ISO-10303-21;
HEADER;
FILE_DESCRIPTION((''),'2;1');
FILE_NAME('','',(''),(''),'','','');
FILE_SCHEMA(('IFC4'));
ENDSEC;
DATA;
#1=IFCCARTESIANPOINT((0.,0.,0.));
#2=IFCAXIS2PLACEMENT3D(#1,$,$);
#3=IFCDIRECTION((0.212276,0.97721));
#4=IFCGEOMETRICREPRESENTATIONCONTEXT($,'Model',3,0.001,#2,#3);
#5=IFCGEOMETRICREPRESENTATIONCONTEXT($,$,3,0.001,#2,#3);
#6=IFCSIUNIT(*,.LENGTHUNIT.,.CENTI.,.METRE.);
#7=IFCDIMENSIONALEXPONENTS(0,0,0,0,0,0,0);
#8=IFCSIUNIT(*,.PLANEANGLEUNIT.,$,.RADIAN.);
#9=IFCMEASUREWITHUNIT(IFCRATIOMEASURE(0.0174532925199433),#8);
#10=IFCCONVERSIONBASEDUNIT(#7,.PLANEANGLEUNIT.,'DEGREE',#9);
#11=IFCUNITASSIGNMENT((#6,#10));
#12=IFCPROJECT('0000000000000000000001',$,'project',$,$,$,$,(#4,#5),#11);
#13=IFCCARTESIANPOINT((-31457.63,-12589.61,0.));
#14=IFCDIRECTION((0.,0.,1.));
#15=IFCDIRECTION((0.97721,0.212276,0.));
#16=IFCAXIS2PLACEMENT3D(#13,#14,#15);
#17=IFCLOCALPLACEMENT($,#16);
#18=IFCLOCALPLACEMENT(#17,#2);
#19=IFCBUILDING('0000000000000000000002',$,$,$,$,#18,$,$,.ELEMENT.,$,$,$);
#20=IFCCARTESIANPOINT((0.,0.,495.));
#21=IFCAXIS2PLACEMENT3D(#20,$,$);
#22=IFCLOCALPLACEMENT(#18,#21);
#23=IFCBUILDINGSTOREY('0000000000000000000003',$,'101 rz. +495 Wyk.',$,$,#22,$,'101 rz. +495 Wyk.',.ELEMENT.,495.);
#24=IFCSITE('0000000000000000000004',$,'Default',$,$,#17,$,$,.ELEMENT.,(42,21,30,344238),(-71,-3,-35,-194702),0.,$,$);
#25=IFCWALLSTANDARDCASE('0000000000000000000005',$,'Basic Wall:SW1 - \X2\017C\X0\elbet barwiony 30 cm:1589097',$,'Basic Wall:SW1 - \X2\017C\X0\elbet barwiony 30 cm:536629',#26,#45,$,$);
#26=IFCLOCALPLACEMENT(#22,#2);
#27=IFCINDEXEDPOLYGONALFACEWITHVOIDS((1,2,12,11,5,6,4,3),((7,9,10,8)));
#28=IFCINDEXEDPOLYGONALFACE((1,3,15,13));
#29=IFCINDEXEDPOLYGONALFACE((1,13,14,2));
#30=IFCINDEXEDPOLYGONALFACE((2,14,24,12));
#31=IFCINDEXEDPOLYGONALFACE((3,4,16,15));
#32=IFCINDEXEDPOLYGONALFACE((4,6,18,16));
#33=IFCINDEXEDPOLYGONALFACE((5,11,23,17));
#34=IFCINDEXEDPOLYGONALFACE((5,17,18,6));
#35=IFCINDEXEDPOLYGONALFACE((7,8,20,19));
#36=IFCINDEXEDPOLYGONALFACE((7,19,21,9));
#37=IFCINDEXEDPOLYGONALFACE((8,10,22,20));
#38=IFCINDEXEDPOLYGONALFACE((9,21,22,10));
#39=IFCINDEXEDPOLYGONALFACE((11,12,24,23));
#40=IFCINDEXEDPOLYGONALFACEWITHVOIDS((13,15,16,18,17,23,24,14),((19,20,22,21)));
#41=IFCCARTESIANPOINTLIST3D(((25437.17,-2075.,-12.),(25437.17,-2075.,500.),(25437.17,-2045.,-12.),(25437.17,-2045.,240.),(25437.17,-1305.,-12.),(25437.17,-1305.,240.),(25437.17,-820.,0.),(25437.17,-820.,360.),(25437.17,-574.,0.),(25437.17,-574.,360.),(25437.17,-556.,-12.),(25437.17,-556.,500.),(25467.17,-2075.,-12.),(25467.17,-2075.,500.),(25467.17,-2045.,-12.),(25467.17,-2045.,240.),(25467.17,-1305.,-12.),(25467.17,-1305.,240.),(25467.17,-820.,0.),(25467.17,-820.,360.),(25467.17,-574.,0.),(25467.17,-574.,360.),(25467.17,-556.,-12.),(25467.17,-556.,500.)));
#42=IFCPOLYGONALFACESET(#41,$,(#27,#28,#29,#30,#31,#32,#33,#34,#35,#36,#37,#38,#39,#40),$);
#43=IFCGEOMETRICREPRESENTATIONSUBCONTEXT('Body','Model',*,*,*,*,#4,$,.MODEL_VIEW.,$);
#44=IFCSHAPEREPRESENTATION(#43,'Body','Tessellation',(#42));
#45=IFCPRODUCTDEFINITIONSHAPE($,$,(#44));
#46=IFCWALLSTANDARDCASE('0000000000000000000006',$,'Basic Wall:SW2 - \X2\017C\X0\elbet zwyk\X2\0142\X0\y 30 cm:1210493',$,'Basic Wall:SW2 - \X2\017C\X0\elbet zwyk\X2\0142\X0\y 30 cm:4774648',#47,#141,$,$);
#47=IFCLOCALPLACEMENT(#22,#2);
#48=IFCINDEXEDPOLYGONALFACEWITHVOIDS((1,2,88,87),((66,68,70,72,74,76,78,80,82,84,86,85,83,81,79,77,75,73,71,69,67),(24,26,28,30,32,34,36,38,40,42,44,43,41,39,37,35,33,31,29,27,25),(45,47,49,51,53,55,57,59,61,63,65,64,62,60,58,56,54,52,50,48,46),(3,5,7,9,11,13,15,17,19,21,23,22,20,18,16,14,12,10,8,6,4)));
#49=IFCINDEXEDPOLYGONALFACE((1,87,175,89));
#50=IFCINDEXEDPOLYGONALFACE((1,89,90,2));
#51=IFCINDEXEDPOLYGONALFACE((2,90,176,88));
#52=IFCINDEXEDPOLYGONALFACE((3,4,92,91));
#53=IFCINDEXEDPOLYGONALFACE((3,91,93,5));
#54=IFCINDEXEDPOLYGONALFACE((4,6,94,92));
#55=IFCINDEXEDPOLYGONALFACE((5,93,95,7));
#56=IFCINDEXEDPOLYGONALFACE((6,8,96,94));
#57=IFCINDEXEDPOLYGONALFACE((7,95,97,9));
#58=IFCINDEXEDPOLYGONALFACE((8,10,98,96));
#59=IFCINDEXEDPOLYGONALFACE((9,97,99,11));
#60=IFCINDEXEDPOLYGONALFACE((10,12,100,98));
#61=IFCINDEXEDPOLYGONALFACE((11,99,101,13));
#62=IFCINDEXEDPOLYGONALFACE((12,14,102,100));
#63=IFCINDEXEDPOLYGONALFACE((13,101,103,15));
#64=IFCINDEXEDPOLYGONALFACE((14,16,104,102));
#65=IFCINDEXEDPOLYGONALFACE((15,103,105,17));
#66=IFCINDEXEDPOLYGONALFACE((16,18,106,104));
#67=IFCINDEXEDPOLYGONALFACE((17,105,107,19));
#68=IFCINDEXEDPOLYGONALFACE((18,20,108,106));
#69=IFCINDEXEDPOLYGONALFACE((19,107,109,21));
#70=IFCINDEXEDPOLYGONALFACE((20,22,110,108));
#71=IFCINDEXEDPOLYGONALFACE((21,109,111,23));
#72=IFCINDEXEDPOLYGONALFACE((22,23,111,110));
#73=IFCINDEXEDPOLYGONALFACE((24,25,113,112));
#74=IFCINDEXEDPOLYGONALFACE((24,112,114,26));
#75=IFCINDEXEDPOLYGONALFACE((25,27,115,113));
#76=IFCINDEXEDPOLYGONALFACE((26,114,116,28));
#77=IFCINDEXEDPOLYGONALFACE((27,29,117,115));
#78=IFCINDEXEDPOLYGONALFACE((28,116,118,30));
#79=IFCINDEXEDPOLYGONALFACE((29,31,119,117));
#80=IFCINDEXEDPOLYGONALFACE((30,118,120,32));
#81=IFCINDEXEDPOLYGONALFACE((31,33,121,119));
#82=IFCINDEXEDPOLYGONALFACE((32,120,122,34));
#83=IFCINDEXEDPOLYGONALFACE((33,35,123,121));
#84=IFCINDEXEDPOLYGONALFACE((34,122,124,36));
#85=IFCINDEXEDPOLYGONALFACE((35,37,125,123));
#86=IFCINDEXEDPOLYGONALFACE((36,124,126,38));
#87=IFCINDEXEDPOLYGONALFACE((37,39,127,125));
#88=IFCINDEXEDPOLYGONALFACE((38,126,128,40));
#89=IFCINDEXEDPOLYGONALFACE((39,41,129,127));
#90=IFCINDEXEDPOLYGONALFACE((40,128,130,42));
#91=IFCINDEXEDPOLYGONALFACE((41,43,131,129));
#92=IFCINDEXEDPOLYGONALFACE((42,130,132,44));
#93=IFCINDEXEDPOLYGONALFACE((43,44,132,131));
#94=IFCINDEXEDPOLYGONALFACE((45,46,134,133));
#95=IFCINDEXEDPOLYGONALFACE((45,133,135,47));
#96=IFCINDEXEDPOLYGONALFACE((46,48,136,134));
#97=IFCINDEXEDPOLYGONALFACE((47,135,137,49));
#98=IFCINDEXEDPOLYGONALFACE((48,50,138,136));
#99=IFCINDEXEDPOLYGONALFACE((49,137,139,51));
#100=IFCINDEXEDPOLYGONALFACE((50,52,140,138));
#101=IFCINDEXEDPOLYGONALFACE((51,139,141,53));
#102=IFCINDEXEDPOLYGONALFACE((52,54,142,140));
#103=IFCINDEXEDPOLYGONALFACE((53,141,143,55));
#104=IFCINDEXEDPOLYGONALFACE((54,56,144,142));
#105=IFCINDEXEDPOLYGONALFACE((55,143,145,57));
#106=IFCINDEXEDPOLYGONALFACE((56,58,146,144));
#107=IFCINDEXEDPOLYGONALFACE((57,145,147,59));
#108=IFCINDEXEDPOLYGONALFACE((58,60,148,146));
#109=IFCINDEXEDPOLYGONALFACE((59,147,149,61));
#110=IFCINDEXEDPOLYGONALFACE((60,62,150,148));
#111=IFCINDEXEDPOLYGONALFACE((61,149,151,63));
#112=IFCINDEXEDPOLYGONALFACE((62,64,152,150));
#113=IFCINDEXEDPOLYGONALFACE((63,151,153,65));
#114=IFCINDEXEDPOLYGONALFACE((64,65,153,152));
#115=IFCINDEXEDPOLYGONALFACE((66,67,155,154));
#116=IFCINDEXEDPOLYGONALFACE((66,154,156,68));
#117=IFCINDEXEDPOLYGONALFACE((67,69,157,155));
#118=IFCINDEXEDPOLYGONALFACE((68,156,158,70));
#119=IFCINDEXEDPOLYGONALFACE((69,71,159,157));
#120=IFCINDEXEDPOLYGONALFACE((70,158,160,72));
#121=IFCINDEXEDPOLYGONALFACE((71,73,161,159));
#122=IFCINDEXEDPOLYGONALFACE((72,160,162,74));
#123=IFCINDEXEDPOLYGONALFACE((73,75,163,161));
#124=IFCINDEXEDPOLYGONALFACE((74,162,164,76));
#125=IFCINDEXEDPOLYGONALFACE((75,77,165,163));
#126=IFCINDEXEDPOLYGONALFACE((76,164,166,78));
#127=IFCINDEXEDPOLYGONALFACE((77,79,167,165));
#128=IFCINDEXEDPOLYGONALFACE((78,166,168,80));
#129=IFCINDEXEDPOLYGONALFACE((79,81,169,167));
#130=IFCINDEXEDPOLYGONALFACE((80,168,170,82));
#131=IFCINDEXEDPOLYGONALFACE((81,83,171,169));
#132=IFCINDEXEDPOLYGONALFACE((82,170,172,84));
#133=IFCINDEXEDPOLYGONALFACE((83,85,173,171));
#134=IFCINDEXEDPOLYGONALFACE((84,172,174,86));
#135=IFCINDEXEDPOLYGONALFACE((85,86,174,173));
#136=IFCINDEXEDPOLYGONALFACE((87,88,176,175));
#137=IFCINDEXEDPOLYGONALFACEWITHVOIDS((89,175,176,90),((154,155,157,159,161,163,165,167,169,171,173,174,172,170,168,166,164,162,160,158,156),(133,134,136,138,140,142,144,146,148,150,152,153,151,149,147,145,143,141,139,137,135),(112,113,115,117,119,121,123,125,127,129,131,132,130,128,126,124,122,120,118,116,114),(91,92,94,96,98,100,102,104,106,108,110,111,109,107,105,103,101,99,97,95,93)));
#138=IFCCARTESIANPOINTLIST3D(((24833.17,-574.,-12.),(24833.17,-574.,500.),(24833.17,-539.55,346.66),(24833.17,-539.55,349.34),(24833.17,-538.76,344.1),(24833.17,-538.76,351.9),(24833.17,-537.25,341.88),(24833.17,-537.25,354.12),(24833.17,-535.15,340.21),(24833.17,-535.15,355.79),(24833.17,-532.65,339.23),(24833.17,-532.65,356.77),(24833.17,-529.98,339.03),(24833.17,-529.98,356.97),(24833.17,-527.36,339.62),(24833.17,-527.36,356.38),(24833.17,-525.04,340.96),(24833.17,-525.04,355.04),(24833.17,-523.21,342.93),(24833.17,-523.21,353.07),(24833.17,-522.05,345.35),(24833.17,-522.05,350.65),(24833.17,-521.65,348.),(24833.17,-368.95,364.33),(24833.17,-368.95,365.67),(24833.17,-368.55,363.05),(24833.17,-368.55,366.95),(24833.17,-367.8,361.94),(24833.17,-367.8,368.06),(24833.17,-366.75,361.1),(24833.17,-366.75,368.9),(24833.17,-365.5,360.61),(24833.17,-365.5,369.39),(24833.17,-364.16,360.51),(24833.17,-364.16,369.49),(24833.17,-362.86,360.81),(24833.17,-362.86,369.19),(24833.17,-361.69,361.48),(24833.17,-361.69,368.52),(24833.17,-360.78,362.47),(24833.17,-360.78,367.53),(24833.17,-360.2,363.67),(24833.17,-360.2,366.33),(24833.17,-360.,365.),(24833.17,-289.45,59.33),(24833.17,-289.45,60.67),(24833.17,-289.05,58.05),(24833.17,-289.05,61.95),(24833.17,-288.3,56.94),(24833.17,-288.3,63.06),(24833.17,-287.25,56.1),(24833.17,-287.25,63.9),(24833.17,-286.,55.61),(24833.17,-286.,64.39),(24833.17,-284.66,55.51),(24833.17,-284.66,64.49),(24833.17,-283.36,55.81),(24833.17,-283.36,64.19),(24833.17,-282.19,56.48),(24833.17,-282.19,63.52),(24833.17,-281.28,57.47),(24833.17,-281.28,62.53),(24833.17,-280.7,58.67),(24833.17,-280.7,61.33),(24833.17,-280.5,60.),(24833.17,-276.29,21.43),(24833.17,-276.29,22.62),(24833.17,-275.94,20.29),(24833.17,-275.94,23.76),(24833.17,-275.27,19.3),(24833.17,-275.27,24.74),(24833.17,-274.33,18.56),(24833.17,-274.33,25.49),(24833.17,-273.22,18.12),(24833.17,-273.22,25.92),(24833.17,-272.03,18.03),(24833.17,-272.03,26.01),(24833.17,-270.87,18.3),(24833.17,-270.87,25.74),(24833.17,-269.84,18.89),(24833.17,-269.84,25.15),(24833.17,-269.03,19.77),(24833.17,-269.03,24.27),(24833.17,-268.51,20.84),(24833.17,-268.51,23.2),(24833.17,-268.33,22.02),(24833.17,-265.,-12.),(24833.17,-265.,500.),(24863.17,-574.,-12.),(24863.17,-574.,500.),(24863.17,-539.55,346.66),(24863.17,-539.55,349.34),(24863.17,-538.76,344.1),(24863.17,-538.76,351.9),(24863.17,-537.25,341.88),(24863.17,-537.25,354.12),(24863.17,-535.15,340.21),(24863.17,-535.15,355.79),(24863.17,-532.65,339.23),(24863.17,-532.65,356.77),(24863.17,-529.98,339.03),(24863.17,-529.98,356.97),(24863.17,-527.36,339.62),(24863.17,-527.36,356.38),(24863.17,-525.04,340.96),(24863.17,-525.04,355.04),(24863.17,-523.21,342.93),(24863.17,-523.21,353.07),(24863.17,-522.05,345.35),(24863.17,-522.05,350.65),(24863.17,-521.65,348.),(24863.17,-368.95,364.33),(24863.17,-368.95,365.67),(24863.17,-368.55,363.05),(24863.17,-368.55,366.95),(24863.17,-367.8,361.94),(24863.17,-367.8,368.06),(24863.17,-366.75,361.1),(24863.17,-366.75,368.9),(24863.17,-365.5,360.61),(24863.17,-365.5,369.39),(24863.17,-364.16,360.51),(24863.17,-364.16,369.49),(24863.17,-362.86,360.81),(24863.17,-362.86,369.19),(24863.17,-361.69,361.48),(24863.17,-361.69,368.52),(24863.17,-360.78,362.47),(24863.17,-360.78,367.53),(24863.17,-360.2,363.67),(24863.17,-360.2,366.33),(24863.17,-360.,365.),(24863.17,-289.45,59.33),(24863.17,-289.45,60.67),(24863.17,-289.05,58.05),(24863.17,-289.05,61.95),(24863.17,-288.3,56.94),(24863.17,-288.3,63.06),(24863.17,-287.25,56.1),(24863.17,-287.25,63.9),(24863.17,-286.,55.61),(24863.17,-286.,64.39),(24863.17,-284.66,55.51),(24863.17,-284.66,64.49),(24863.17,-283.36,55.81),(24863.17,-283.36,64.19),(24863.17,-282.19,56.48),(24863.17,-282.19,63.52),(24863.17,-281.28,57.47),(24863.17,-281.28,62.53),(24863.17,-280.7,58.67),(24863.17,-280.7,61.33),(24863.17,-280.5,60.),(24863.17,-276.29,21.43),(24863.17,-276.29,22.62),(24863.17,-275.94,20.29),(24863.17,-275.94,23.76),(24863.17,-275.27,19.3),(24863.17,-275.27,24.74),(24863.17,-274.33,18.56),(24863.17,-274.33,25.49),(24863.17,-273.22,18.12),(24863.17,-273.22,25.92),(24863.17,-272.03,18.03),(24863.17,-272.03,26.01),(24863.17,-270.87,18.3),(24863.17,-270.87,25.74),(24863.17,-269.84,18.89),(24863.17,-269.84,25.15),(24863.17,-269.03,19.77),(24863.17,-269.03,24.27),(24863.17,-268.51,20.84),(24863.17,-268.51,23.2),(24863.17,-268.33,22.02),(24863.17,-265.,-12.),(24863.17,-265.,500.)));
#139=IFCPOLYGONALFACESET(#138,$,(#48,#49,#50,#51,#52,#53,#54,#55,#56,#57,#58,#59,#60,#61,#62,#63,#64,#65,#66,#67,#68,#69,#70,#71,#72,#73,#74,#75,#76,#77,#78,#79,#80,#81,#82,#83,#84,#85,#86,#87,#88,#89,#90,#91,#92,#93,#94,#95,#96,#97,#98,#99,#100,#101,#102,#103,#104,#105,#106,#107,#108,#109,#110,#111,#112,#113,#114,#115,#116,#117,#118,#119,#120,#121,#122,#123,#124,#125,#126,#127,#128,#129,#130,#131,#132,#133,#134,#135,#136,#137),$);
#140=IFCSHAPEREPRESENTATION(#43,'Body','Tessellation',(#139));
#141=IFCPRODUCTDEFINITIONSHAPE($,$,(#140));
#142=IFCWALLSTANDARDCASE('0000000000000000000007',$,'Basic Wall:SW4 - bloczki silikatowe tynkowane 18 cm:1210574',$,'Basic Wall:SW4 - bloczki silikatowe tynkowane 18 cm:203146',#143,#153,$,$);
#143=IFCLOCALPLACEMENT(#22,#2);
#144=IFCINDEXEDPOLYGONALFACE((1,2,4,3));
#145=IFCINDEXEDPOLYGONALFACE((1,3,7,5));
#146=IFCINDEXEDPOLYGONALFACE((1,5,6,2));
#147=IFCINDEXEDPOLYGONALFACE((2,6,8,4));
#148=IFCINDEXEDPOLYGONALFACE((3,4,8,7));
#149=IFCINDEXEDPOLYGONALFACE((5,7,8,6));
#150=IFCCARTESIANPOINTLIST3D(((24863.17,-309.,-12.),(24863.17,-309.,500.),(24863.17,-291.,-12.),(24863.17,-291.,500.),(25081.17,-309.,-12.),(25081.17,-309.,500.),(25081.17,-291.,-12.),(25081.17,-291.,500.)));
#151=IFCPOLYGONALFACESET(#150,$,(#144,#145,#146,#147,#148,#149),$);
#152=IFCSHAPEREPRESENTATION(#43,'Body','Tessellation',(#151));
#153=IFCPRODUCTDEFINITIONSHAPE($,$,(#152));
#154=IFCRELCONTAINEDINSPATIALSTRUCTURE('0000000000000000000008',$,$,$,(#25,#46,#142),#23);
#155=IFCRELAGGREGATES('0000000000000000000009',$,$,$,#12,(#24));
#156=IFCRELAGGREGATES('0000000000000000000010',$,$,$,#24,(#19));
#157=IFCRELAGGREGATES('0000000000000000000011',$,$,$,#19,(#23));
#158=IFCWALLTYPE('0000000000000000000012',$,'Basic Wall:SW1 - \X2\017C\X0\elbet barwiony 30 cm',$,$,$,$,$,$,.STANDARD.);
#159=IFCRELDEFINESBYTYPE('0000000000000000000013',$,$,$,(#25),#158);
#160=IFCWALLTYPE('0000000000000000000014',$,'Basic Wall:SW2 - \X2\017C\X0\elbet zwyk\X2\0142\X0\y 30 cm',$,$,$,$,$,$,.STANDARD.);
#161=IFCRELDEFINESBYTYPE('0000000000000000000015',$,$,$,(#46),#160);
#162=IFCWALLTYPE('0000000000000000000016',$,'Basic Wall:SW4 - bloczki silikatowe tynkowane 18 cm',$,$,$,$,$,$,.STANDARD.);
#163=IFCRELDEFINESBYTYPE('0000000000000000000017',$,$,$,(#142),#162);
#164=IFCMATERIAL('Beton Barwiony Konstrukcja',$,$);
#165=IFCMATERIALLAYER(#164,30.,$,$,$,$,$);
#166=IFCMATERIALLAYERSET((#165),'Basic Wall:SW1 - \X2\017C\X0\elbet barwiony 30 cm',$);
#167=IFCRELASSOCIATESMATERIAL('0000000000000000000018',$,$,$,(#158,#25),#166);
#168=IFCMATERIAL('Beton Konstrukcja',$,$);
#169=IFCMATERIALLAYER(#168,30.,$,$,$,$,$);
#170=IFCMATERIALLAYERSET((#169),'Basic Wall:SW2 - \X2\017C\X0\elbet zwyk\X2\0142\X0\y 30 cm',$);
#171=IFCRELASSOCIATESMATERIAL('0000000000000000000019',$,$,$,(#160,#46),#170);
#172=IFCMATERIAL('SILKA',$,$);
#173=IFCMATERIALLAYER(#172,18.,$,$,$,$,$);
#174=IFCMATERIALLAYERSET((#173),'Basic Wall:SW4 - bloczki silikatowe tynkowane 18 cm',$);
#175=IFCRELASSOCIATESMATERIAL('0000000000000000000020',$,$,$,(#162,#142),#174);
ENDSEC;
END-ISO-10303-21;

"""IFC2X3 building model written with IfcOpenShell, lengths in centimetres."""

from ifc_helpers import new_model, entity, si_unit, converted_unit, direction, frame, frame_2d, origin, place, context, subcontext, project, spatial, polyline, rectangle, circle, extrude, clip, bounded_halfspace, material, layer, layer_set, layer_usage, type_object, element, save


model = new_model("IFC2X3")

# Units and contexts
model_context = context("Model", 3, precision=0.001, world=origin(), true_north=direction((0.212276, 0.97721)))
context_of_model = context(None, 3, precision=0.001, world=origin(), true_north=direction((0.212276, 0.97721)))
body_context = subcontext(model_context, "Body", "Model", "MODEL_VIEW")
ifc_project = project(units=[si_unit("LENGTHUNIT", "METRE", prefix="CENTI"), converted_unit("PLANEANGLEUNIT", "DEGREE", entity("IfcRatioMeasure", 0.0174532925199433), si_unit("PLANEANGLEUNIT", "RADIAN"), dimensions=[0, 0, 0, 0, 0, 0, 0])], contexts=[model_context, context_of_model])

# Site, building, storey
site_placement = place(None, frame((-31457.63, -12589.61, 0.0), z_axis=(0.0, 0.0, 1.0), x_axis=(0.97721, 0.212276, 0.0)))
site = spatial("IfcSite", under=ifc_project, at=site_placement, Name="Default", CompositionType="ELEMENT", RefLatitude=(42, 21, 30, 344238), RefLongitude=(-71, -3, -35, -194702), RefElevation=0.0)
building_placement = place(site_placement, origin())
building = spatial("IfcBuilding", under=site, at=building_placement, CompositionType="ELEMENT")
storey_placement = place(building_placement, frame((0.0, 0.0, 495.0)))
storey = spatial("IfcBuildingStorey", under=building, at=storey_placement, Name="101 rz. +495 Wyk.", LongName="101 rz. +495 Wyk.", CompositionType="ELEMENT", Elevation=495.0)

# Walls, openings
ifc_material_1 = material(Name="Beton Barwiony Konstrukcja")
ifc_layer_1 = layer(ifc_material_1, 30.0)
ifc_layer_set_1 = layer_set([ifc_layer_1], Name="Basic Wall:SW1 - żelbet barwiony 30 cm")
ifc_layer_usage_1 = layer_usage(ifc_layer_set_1, "AXIS2", "NEGATIVE", 15.0)
wall_type_1 = type_object("IfcWallType", Name="Basic Wall:SW1 - żelbet barwiony 30 cm", PredefinedType="STANDARD", material=ifc_layer_set_1)
wall_1_placement = place(storey_placement, frame((25452.17, -556.0, -12.0), z_axis=(0.0, 0.0, 1.0), x_axis=(0.0, -1.0, 0.0)))
wall_1 = element("IfcWallStandardCase", 1, at=wall_1_placement, inside=storey, type_object=wall_type_1, material=ifc_layer_usage_1, Name="Basic Wall:SW1 - żelbet barwiony 30 cm:1589097", ObjectType="Basic Wall:SW1 - żelbet barwiony 30 cm:536629", context=body_context, shape_type="Clipping", body=[
    clip(extrude(rectangle(XDim=1519.0, YDim=30.0, at=frame_2d((759.5, 0.0), x_axis=(-1.0, 0.0))), origin(), (0.0, 0.0, 1.0), 537.0), bounded_halfspace(frame((1519.0, 15.0, 512.0), z_axis=(0.0, 0.0, -1.0), x_axis=(0.0, 1.0, 0.0)), True, frame((1519.0, 15.0, 512.0)), polyline([(0.0, 0.0), (-1519.0, 0.0), (-1519.0, -30.0), (-820.0, -30.0), (-790.0, -30.0), (0.0, -30.0), (0.0, 0.0)]))),
])
opening_1_placement = place(wall_1_placement, frame((264.0, -30.24, 12.0)))
element("IfcOpeningElement", 2, at=opening_1_placement, cuts=wall_1, ObjectType="Opening", context=body_context, shape_type="SweptSolid", body=[
    extrude(rectangle(XDim=360.0, YDim=246.0, at=frame_2d((0.0, 0.0), x_axis=(0.0, 1.0))), frame((-123.0, 0.0, 180.0), z_axis=(0.0, 1.0, 0.0), x_axis=(-1.0, 0.0, 0.0)), (0.0, 0.0, 1.0), 60.48),
])
opening_2_placement = place(wall_1_placement, origin())
element("IfcOpeningElement", 3, at=opening_2_placement, cuts=wall_1, ObjectType="Opening", context=body_context, shape_type="SweptSolid", body=[
    extrude(rectangle(XDim=252.0, YDim=740.0, at=frame_2d((0.0, 0.0), x_axis=(0.0, 1.0))), frame((1119.0, 15.0, 126.0), z_axis=(0.0, -1.0, 0.0), x_axis=(1.0, 0.0, 0.0)), (0.0, 0.0, 1.0), 30.0),
])
ifc_material_2 = material(Name="Beton Konstrukcja")
ifc_layer_2 = layer(ifc_material_2, 30.0)
ifc_layer_set_2 = layer_set([ifc_layer_2], Name="Basic Wall:SW2 - żelbet zwykły 30 cm")
ifc_layer_usage_2 = layer_usage(ifc_layer_set_2, "AXIS2", "NEGATIVE", 15.0)
wall_type_2 = type_object("IfcWallType", Name="Basic Wall:SW2 - żelbet zwykły 30 cm", PredefinedType="STANDARD", material=ifc_layer_set_2)
wall_2_placement = place(storey_placement, frame((24848.17, -265.0, -12.0), z_axis=(0.0, 0.0, 1.0), x_axis=(0.0, -1.0, 0.0)))
wall_2 = element("IfcWallStandardCase", 4, at=wall_2_placement, inside=storey, type_object=wall_type_2, material=ifc_layer_usage_2, Name="Basic Wall:SW2 - żelbet zwykły 30 cm:1210493", ObjectType="Basic Wall:SW2 - żelbet zwykły 30 cm:4774648", context=body_context, shape_type="Clipping", body=[
    clip(extrude(rectangle(XDim=309.0, YDim=30.0, at=frame_2d((154.5, 0.0), x_axis=(-1.0, 0.0))), origin(), (0.0, 0.0, 1.0), 537.0), bounded_halfspace(frame((0.0, -15.0, 512.0), z_axis=(0.0, 0.0, -1.0), x_axis=(0.0, 1.0, 0.0)), True, frame((0.0, -15.0, 512.0)), polyline([(0.0, 0.0), (309.0, 0.0), (309.0, 30.0), (0.0, 30.0), (0.0, 0.0)]))),
])
opening_3_placement = place(wall_2_placement, origin())
element("IfcOpeningElement", 5, at=opening_3_placement, cuts=wall_2, ObjectType="Opening", context=body_context, shape_type="SweptSolid", body=[
    extrude(circle(Radius=9.0, at=frame_2d((0.0, 0.0), x_axis=(1.0, 0.0))), frame((265.65, 15.0, 360.0), z_axis=(0.0, -1.0, 0.0), x_axis=(-1.0, 0.0, 0.0)), (0.0, 0.0, 1.0), 30.0),
])
opening_4_placement = place(wall_2_placement, origin())
element("IfcOpeningElement", 6, at=opening_4_placement, cuts=wall_2, ObjectType="Opening", context=body_context, shape_type="SweptSolid", body=[
    extrude(circle(Radius=4.5, at=frame_2d((0.0, 0.0), x_axis=(1.0, 0.0))), frame((99.5, 15.0, 377.0), z_axis=(0.0, -1.0, 0.0), x_axis=(-1.0, 0.0, 0.0)), (0.0, 0.0, 1.0), 30.0),
])
opening_5_placement = place(wall_2_placement, origin())
element("IfcOpeningElement", 7, at=opening_5_placement, cuts=wall_2, ObjectType="Opening", context=body_context, shape_type="SweptSolid", body=[
    extrude(circle(Radius=4.5, at=frame_2d((0.0, 0.0), x_axis=(1.0, 0.0))), frame((20.0, 15.0, 72.0), z_axis=(0.0, -1.0, 0.0), x_axis=(-1.0, 0.0, 0.0)), (0.0, 0.0, 1.0), 30.0),
])
opening_6_placement = place(wall_2_placement, origin())
element("IfcOpeningElement", 8, at=opening_6_placement, cuts=wall_2, ObjectType="Opening", context=body_context, shape_type="SweptSolid", body=[
    extrude(circle(Radius=4.0, at=frame_2d((0.0, 0.0), x_axis=(1.0, 0.0))), frame((7.33, 15.0, 34.02), z_axis=(0.0, -1.0, 0.0), x_axis=(-1.0, 0.0, 0.0)), (0.0, 0.0, 1.0), 30.0),
])

# Shared definitions
ifc_material_3 = material(Name="SILKA")
ifc_layer_3 = layer(ifc_material_3, 18.0)
ifc_layer_set_3 = layer_set([ifc_layer_3], Name="Basic Wall:SW4 - bloczki silikatowe tynkowane 18 cm")
wall_type_3 = type_object("IfcWallType", Name="Basic Wall:SW4 - bloczki silikatowe tynkowane 18 cm", PredefinedType="STANDARD", material=ifc_layer_set_3)

# Wall
ifc_layer_usage_3 = layer_usage(ifc_layer_set_3, "AXIS2", "NEGATIVE", 9.0)
wall_3_placement = place(storey_placement, frame((24863.17, -300.0, -12.0)))
element("IfcWallStandardCase", 9, at=wall_3_placement, inside=storey, type_object=wall_type_3, material=ifc_layer_usage_3, Name="Basic Wall:SW4 - bloczki silikatowe tynkowane 18 cm:1210574", ObjectType="Basic Wall:SW4 - bloczki silikatowe tynkowane 18 cm:203146", context=body_context, shape_type="Clipping", body=[
    clip(extrude(rectangle(XDim=218.0, YDim=18.0, at=frame_2d((109.0, 0.0), x_axis=(-1.0, 0.0))), origin(), (0.0, 0.0, 1.0), 537.0), bounded_halfspace(frame((0.0, -9.0, 512.0), z_axis=(0.0, 0.0, -1.0), x_axis=(1.0, 0.0, 0.0)), True, frame((0.0, -9.0, 512.0)), polyline([(0.0, 0.0), (218.0, 0.0), (218.0, 18.0), (0.0, 18.0), (0.0, 0.0)]))),
])

save(model, "model.ifc")
